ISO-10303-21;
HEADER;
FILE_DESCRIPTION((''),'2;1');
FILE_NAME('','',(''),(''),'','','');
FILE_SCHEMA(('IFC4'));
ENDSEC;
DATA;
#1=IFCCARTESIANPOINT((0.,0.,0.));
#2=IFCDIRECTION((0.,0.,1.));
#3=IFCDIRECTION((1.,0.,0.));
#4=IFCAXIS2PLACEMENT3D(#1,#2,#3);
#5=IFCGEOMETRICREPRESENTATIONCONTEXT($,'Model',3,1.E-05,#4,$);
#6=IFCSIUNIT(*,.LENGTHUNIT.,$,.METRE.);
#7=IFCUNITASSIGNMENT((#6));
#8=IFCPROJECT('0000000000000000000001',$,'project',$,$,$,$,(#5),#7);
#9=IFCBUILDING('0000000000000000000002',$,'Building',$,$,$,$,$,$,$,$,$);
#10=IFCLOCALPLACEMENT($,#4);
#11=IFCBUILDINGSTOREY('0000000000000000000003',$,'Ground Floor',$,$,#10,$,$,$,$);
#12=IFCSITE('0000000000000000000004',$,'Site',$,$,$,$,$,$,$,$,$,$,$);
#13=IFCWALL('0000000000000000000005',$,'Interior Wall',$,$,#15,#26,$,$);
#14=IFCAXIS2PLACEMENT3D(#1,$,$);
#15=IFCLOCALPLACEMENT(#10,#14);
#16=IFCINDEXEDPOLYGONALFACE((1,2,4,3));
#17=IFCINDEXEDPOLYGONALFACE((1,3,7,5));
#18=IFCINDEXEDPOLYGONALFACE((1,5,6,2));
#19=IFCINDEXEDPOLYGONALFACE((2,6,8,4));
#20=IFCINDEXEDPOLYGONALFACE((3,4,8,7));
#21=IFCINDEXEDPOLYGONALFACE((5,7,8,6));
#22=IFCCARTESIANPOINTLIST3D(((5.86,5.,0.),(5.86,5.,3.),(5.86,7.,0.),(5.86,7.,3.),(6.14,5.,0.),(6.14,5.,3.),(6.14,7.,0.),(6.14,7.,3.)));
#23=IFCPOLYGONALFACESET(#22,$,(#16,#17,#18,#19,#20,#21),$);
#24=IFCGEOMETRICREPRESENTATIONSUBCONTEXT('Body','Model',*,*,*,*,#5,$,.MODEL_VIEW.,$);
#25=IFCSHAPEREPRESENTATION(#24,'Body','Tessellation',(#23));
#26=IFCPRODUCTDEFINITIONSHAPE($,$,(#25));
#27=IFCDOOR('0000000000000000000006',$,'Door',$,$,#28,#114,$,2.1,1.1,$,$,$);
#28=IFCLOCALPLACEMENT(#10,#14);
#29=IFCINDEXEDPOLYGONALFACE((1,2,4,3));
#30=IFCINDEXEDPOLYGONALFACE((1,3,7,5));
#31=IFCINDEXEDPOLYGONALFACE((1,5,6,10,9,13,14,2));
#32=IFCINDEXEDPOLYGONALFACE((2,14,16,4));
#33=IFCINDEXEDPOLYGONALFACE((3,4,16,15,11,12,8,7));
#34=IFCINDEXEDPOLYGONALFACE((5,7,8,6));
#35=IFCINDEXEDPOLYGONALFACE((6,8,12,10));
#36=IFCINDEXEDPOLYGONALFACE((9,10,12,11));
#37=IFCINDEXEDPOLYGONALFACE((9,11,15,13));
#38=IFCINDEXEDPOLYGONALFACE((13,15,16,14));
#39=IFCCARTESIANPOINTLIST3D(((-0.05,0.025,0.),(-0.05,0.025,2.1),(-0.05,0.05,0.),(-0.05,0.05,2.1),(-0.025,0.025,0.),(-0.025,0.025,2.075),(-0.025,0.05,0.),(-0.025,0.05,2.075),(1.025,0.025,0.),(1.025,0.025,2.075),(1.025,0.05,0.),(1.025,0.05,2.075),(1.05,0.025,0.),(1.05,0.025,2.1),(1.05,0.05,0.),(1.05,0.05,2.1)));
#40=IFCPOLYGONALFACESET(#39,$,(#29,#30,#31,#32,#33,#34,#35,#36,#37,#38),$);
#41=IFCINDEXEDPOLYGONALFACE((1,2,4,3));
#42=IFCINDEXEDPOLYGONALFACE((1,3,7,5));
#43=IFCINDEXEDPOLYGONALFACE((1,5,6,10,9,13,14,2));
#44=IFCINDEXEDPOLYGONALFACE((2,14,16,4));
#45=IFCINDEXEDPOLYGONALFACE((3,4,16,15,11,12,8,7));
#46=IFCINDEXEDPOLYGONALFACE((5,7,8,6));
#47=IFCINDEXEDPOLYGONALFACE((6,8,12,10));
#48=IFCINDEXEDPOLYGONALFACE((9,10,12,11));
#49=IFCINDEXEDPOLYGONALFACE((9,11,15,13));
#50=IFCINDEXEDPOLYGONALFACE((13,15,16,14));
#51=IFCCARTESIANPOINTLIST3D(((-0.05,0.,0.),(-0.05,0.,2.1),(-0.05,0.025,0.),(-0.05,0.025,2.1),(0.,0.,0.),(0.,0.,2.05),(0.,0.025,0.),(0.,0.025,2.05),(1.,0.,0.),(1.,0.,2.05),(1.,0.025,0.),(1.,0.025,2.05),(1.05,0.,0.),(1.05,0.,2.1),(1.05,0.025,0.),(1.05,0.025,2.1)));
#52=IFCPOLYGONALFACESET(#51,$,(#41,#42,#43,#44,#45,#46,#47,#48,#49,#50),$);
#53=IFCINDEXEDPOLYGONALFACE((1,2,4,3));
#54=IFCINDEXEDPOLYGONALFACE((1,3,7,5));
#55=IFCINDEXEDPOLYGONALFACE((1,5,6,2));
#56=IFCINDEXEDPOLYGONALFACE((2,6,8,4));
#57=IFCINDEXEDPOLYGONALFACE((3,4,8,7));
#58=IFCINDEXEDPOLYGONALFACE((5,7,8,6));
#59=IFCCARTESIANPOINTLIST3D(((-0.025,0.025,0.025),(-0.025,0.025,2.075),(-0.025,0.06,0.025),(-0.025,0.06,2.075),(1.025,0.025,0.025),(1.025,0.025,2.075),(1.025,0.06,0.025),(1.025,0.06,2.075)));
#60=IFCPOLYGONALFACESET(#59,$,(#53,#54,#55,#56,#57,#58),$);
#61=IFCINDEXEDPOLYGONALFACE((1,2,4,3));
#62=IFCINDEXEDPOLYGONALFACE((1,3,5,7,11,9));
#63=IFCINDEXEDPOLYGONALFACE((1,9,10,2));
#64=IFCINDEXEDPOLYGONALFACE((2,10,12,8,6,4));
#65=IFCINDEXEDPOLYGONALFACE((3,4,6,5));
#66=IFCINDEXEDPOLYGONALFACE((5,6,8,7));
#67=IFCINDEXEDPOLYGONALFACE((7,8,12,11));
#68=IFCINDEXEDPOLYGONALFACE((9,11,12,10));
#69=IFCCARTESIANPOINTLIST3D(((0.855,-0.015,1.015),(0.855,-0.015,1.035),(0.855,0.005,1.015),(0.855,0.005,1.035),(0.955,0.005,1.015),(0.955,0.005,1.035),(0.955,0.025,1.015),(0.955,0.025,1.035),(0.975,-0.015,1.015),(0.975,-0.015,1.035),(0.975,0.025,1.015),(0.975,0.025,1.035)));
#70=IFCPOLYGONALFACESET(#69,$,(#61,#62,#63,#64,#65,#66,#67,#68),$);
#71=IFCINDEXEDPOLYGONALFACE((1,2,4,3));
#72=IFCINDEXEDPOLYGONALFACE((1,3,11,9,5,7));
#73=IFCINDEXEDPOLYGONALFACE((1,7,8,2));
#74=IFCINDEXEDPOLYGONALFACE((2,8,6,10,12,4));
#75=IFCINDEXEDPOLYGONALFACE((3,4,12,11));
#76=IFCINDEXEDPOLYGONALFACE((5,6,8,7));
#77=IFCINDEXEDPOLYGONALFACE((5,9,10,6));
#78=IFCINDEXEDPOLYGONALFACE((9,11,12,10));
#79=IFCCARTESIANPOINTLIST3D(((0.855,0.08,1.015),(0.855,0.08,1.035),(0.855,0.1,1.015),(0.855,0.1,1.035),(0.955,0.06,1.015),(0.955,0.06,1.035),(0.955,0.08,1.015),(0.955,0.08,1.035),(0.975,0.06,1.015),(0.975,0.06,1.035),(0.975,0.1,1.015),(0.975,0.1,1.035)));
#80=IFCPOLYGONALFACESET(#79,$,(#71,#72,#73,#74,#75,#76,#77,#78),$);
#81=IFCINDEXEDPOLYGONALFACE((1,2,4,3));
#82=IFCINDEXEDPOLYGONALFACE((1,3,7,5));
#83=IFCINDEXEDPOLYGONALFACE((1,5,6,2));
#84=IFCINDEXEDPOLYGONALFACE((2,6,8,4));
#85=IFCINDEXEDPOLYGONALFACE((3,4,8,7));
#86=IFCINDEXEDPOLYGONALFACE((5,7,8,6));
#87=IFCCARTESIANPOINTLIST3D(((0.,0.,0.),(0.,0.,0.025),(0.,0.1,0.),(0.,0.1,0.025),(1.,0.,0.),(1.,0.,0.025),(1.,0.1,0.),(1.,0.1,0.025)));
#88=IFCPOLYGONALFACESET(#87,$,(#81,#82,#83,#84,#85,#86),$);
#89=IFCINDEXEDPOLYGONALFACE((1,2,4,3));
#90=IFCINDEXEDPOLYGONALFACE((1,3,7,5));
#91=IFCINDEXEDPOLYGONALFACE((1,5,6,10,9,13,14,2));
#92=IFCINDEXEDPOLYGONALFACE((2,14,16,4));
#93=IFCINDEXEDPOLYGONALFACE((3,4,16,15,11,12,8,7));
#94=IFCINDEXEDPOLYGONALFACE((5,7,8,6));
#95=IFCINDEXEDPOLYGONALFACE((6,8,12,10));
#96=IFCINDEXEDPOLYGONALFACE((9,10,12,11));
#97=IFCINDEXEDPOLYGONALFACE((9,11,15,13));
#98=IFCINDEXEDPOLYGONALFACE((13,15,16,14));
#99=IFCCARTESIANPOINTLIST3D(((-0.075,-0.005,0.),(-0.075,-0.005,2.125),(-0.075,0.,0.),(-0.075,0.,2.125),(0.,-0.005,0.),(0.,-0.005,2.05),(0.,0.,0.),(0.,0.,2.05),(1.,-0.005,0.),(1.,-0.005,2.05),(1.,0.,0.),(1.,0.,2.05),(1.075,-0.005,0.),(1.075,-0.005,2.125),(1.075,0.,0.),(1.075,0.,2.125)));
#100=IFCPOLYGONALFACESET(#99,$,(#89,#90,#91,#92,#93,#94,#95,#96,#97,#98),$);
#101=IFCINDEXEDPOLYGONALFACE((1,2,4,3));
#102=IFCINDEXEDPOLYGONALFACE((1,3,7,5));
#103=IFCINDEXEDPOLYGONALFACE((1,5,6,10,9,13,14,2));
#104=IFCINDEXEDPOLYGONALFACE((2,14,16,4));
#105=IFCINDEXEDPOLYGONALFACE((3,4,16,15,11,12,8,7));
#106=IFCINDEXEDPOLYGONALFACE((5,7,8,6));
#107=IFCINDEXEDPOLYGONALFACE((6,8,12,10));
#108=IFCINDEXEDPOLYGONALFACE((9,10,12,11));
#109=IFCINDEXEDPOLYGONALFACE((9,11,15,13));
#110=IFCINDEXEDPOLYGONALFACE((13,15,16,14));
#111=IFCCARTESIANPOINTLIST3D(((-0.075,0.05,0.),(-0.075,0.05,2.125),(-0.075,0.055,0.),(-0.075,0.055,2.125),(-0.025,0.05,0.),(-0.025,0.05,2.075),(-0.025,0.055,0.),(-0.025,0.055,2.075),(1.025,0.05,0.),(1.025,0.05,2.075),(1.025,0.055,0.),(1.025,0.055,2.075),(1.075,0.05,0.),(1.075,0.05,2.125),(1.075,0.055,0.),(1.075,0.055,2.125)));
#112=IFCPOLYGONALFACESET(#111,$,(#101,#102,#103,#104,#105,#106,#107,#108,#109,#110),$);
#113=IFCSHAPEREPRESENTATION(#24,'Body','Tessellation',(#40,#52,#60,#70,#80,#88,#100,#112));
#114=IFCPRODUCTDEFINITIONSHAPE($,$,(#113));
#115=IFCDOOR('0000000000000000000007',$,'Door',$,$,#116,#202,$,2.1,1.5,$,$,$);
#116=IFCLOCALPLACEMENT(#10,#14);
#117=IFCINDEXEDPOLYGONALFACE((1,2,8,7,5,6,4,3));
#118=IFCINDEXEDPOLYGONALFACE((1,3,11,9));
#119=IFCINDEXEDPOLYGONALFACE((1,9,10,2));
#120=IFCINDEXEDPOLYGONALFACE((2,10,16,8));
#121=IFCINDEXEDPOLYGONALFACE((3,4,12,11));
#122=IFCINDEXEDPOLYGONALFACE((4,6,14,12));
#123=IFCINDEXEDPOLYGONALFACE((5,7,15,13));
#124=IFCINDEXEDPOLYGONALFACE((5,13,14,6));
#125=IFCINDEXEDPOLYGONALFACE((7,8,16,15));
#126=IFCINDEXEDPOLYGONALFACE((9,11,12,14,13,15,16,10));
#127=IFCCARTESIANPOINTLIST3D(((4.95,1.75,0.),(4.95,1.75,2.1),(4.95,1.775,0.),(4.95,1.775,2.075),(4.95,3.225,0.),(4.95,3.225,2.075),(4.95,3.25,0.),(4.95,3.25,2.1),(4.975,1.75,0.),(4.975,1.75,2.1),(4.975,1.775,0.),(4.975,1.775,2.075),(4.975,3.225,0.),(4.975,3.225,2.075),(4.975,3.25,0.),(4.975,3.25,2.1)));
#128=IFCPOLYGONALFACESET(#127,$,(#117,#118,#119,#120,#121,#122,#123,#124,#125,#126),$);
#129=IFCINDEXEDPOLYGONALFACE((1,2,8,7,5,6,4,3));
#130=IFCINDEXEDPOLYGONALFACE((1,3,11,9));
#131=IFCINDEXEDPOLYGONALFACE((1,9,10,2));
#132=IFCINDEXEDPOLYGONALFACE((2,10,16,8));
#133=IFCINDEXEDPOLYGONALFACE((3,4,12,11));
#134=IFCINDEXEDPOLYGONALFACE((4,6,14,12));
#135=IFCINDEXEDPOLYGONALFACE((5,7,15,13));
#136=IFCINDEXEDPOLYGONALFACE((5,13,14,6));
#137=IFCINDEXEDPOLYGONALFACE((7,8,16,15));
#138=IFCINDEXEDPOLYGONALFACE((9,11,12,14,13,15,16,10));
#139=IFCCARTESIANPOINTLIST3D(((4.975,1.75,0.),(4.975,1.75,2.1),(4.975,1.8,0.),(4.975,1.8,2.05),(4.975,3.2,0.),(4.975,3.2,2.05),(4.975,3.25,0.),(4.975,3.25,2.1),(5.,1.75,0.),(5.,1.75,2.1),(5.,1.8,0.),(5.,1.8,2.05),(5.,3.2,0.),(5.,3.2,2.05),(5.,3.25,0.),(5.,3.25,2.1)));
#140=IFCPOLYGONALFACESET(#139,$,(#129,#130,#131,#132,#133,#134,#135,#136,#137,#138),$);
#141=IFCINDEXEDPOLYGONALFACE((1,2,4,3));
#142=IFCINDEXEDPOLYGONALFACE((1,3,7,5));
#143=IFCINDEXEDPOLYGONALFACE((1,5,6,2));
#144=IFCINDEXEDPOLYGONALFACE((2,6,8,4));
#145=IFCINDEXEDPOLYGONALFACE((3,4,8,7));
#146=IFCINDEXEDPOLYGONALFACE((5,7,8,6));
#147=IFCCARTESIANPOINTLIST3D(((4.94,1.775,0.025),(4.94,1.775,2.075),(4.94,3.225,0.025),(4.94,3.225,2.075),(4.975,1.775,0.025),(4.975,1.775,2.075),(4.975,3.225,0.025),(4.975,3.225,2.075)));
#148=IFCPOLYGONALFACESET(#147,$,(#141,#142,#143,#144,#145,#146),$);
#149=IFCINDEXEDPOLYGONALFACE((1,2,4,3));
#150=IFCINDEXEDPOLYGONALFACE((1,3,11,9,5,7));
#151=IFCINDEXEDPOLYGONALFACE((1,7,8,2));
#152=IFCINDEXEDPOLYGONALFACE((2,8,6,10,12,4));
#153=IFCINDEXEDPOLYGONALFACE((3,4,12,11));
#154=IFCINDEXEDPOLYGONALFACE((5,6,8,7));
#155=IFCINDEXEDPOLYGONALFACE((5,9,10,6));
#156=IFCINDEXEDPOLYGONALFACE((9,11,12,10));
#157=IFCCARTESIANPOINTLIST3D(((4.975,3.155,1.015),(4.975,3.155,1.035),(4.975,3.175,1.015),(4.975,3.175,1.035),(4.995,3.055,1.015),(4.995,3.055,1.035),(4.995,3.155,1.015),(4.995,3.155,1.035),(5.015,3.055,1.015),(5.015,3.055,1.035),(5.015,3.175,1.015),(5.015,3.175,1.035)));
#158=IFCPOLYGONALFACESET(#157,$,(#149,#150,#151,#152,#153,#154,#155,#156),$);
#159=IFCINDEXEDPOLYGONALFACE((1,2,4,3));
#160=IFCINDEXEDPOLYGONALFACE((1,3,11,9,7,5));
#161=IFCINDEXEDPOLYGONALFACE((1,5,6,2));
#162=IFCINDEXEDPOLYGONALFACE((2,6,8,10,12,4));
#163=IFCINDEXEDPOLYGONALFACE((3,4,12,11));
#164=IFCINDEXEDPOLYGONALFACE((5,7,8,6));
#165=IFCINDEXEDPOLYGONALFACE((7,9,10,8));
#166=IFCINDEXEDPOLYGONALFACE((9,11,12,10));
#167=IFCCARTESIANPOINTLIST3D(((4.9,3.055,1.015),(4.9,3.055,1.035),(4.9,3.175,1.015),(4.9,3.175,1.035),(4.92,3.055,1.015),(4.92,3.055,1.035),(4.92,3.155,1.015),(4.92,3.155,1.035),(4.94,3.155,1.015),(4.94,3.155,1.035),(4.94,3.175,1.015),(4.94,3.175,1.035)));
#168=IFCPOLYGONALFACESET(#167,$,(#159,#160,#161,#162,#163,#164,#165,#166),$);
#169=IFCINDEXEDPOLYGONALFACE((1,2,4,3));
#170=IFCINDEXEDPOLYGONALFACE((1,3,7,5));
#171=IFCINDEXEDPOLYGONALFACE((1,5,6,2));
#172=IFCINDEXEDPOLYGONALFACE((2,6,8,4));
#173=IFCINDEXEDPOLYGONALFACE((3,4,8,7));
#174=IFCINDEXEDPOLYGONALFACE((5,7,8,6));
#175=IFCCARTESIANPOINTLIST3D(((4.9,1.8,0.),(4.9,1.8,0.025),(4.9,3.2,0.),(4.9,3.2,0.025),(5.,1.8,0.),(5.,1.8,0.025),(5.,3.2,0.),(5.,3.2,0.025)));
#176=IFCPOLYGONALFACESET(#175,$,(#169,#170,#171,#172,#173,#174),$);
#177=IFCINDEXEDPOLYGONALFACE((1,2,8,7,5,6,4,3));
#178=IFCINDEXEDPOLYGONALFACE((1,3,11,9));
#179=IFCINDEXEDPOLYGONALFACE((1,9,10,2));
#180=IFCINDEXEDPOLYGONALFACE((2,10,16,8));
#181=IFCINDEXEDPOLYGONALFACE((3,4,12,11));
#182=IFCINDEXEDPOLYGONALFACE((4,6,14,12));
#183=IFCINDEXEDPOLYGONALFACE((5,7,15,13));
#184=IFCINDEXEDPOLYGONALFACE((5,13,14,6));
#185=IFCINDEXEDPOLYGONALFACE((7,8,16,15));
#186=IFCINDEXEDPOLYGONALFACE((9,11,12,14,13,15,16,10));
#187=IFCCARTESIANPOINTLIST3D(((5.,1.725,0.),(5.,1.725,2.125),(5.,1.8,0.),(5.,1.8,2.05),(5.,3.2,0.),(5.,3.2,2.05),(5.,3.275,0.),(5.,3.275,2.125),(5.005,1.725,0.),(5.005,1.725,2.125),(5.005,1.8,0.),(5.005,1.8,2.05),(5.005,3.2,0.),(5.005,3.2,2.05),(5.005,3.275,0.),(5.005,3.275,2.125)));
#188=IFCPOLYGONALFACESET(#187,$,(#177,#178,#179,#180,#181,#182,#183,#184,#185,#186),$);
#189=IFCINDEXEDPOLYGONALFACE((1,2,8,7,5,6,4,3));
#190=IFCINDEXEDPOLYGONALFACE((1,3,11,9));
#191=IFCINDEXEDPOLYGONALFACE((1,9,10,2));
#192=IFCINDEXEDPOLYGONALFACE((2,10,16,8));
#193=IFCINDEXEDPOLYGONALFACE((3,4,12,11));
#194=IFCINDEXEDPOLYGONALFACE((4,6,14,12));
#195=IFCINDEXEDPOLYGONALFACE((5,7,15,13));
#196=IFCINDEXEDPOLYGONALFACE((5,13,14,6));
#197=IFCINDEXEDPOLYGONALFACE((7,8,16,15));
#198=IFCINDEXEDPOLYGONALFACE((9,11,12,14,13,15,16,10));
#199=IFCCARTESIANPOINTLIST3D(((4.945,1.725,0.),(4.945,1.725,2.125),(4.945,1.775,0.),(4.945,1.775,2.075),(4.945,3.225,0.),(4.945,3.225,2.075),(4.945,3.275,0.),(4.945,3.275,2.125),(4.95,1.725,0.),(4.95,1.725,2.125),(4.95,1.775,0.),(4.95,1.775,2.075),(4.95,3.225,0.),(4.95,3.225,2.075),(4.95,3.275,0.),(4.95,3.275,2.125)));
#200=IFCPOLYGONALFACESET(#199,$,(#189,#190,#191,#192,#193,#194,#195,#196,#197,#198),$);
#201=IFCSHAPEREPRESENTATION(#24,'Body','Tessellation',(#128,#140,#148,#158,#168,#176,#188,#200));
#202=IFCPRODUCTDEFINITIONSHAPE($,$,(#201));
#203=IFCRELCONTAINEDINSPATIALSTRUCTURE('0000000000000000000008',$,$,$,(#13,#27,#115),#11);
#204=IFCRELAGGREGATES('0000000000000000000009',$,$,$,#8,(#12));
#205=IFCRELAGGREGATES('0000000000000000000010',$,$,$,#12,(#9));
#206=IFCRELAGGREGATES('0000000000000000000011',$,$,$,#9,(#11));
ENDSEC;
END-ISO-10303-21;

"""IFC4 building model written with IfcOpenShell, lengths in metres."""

from ifc_helpers import new_model, si_unit, frame, origin_with_axes, place, context, subcontext, project, spatial, line, indexed_curve, outline, extrude, element, save


model = new_model("IFC4")

# Units and contexts
model_context = context("Model", 3, precision=1e-05, world=origin_with_axes())
body_context = subcontext(model_context, "Body", "Model", "MODEL_VIEW")
ifc_project = project(units=[si_unit("LENGTHUNIT", "METRE")], contexts=[model_context])

# Site, building, storey
site = spatial("IfcSite", under=ifc_project, Name="Site")
building = spatial("IfcBuilding", under=site, Name="Building")
storey_placement = place(None, origin_with_axes())
storey = spatial("IfcBuildingStorey", under=building, at=storey_placement, Name="Ground Floor")

# Wall
wall_1_placement = place(storey_placement, frame((6.0, 5.0, 0.0), z_axis=(0.0, 0.0, 1.0), x_axis=(0.0, 1.0, 0.0)))
element("IfcWall", 1, at=wall_1_placement, inside=storey, Name="Interior Wall", context=body_context, shape_type="SweptSolid", body=[
    extrude(outline(indexed_curve([(0.0, 0.0), (0.0, 0.28), (2.0, 0.28), (2.0, 0.0), (0.0, 0.0)], self_intersect=False)), frame((0.0, -0.14, 0.0), z_axis=(0.0, 0.0, 1.0), x_axis=(1.0, 0.0, 0.0)), (0.0, 0.0, 1.0), 3.0),
])

# Doors
door_1_placement = place(storey_placement, frame((-0.05, 0.0, 0.0), z_axis=(0.0, 0.0, 1.0), x_axis=(1.0, 0.0, 0.0)))
element("IfcDoor", 2, at=door_1_placement, inside=storey, Name="Door", OverallHeight=2.1, OverallWidth=1.1, context=body_context, shape_type="SweptSolid", body=[
    extrude(outline(indexed_curve([(0.0, 0.0), (0.0, 2.1), (1.1, 2.1), (1.1, 0.0), (1.075, 0.0), (1.075, 2.075), (0.025, 2.075), (0.025, 0.0)], segments=[line(1, 2, 3, 4, 5, 6, 7, 8, 1)])), frame((0.0, 0.025, 0.0), z_axis=(0.0, -1.0, 0.0), x_axis=(1.0, 0.0, 0.0)), (0.0, 0.0, -1.0), 0.025),
    extrude(outline(indexed_curve([(0.0, 0.0), (0.0, 2.1), (1.1, 2.1), (1.1, 0.0), (1.05, 0.0), (1.05, 2.05), (0.05, 2.05), (0.05, 0.0)], segments=[line(1, 2, 3, 4, 5, 6, 7, 8, 1)])), frame((0.0, 0.0, 0.0), z_axis=(0.0, -1.0, 0.0), x_axis=(1.0, 0.0, 0.0)), (0.0, 0.0, -1.0), 0.025),
    extrude(outline(indexed_curve([(0.0, 0.0), (1.05, 0.0), (1.05, 0.035), (0.0, 0.035)], segments=[line(1, 2, 3, 4, 1)])), frame((0.025, 0.025, 0.025), z_axis=(0.0, 0.0, 1.0), x_axis=(1.0, 0.0, 0.0)), (0.0, 0.0, 1.0), 2.05),
    extrude(outline(indexed_curve([(0.0, 0.0), (0.0, -0.04), (-0.12, -0.04), (-0.12, -0.02), (-0.02, -0.02), (-0.02, 0.0)], segments=[line(1, 2, 3, 4, 5, 6, 1)])), frame((1.025, 0.025, 1.015), z_axis=(0.0, 0.0, 1.0), x_axis=(1.0, 0.0, 0.0)), (0.0, 0.0, 1.0), 0.02),
    extrude(outline(indexed_curve([(0.0, 0.0), (0.0, 0.04), (-0.12, 0.04), (-0.12, 0.02), (-0.02, 0.02), (-0.02, 0.0)], segments=[line(1, 2, 3, 4, 5, 6, 1)])), frame((1.025, 0.06, 1.015), z_axis=(0.0, 0.0, 1.0), x_axis=(1.0, 0.0, 0.0)), (0.0, 0.0, 1.0), 0.02),
    extrude(outline(indexed_curve([(0.0, 0.0), (1.0, 0.0), (1.0, 0.1), (0.0, 0.1)], segments=[line(1, 2, 3, 4, 1)])), frame((0.05, 0.0, 0.0), z_axis=(0.0, 0.0, 1.0), x_axis=(1.0, 0.0, 0.0)), (0.0, 0.0, 1.0), 0.025),
    extrude(outline(indexed_curve([(0.0, 0.0), (0.0, 2.125), (1.15, 2.125), (1.15, 0.0), (1.075, 0.0), (1.075, 2.05), (0.075, 2.05), (0.075, 0.0)], segments=[line(1, 2, 3, 4, 5, 6, 7, 8, 1)])), frame((-0.025, -0.005, 0.0), z_axis=(0.0, -1.0, 0.0), x_axis=(1.0, 0.0, 0.0)), (0.0, 0.0, -1.0), 0.005),
    extrude(outline(indexed_curve([(0.0, 0.0), (0.0, 2.125), (1.15, 2.125), (1.15, 0.0), (1.1, 0.0), (1.1, 2.075), (0.05, 2.075), (0.05, 0.0)], segments=[line(1, 2, 3, 4, 5, 6, 7, 8, 1)])), frame((-0.025, 0.05, 0.0), z_axis=(0.0, -1.0, 0.0), x_axis=(1.0, 0.0, 0.0)), (0.0, 0.0, -1.0), 0.005),
])
door_2_placement = place(storey_placement, frame((5.0, 1.75, 0.0), z_axis=(0.0, 0.0, 1.0), x_axis=(0.0, 1.0, 0.0)))
element("IfcDoor", 3, at=door_2_placement, inside=storey, Name="Door", OverallHeight=2.1, OverallWidth=1.5, context=body_context, shape_type="SweptSolid", body=[
    extrude(outline(indexed_curve([(0.0, 0.0), (0.0, 2.1), (1.5, 2.1), (1.5, 0.0), (1.475, 0.0), (1.475, 2.075), (0.025, 2.075), (0.025, 0.0)], segments=[line(1, 2, 3, 4, 5, 6, 7, 8, 1)])), frame((0.0, 0.025, 0.0), z_axis=(0.0, -1.0, 0.0), x_axis=(1.0, 0.0, 0.0)), (0.0, 0.0, -1.0), 0.025),
    extrude(outline(indexed_curve([(0.0, 0.0), (0.0, 2.1), (1.5, 2.1), (1.5, 0.0), (1.45, 0.0), (1.45, 2.05), (0.05, 2.05), (0.05, 0.0)], segments=[line(1, 2, 3, 4, 5, 6, 7, 8, 1)])), frame((0.0, 0.0, 0.0), z_axis=(0.0, -1.0, 0.0), x_axis=(1.0, 0.0, 0.0)), (0.0, 0.0, -1.0), 0.025),
    extrude(outline(indexed_curve([(0.0, 0.0), (1.45, 0.0), (1.45, 0.035), (0.0, 0.035)], segments=[line(1, 2, 3, 4, 1)])), frame((0.025, 0.025, 0.025), z_axis=(0.0, 0.0, 1.0), x_axis=(1.0, 0.0, 0.0)), (0.0, 0.0, 1.0), 2.05),
    extrude(outline(indexed_curve([(0.0, 0.0), (0.0, -0.04), (-0.12, -0.04), (-0.12, -0.02), (-0.02, -0.02), (-0.02, 0.0)], segments=[line(1, 2, 3, 4, 5, 6, 1)])), frame((1.425, 0.025, 1.015), z_axis=(0.0, 0.0, 1.0), x_axis=(1.0, 0.0, 0.0)), (0.0, 0.0, 1.0), 0.02),
    extrude(outline(indexed_curve([(0.0, 0.0), (0.0, 0.04), (-0.12, 0.04), (-0.12, 0.02), (-0.02, 0.02), (-0.02, 0.0)], segments=[line(1, 2, 3, 4, 5, 6, 1)])), frame((1.425, 0.06, 1.015), z_axis=(0.0, 0.0, 1.0), x_axis=(1.0, 0.0, 0.0)), (0.0, 0.0, 1.0), 0.02),
    extrude(outline(indexed_curve([(0.0, 0.0), (1.4, 0.0), (1.4, 0.1), (0.0, 0.1)], segments=[line(1, 2, 3, 4, 1)])), frame((0.05, 0.0, 0.0), z_axis=(0.0, 0.0, 1.0), x_axis=(1.0, 0.0, 0.0)), (0.0, 0.0, 1.0), 0.025),
    extrude(outline(indexed_curve([(0.0, 0.0), (0.0, 2.125), (1.55, 2.125), (1.55, 0.0), (1.475, 0.0), (1.475, 2.05), (0.075, 2.05), (0.075, 0.0)], segments=[line(1, 2, 3, 4, 5, 6, 7, 8, 1)])), frame((-0.025, -0.005, 0.0), z_axis=(0.0, -1.0, 0.0), x_axis=(1.0, 0.0, 0.0)), (0.0, 0.0, -1.0), 0.005),
    extrude(outline(indexed_curve([(0.0, 0.0), (0.0, 2.125), (1.55, 2.125), (1.55, 0.0), (1.5, 0.0), (1.5, 2.075), (0.05, 2.075), (0.05, 0.0)], segments=[line(1, 2, 3, 4, 5, 6, 7, 8, 1)])), frame((-0.025, 0.05, 0.0), z_axis=(0.0, -1.0, 0.0), x_axis=(1.0, 0.0, 0.0)), (0.0, 0.0, -1.0), 0.005),
])

save(model, "model.ifc")
